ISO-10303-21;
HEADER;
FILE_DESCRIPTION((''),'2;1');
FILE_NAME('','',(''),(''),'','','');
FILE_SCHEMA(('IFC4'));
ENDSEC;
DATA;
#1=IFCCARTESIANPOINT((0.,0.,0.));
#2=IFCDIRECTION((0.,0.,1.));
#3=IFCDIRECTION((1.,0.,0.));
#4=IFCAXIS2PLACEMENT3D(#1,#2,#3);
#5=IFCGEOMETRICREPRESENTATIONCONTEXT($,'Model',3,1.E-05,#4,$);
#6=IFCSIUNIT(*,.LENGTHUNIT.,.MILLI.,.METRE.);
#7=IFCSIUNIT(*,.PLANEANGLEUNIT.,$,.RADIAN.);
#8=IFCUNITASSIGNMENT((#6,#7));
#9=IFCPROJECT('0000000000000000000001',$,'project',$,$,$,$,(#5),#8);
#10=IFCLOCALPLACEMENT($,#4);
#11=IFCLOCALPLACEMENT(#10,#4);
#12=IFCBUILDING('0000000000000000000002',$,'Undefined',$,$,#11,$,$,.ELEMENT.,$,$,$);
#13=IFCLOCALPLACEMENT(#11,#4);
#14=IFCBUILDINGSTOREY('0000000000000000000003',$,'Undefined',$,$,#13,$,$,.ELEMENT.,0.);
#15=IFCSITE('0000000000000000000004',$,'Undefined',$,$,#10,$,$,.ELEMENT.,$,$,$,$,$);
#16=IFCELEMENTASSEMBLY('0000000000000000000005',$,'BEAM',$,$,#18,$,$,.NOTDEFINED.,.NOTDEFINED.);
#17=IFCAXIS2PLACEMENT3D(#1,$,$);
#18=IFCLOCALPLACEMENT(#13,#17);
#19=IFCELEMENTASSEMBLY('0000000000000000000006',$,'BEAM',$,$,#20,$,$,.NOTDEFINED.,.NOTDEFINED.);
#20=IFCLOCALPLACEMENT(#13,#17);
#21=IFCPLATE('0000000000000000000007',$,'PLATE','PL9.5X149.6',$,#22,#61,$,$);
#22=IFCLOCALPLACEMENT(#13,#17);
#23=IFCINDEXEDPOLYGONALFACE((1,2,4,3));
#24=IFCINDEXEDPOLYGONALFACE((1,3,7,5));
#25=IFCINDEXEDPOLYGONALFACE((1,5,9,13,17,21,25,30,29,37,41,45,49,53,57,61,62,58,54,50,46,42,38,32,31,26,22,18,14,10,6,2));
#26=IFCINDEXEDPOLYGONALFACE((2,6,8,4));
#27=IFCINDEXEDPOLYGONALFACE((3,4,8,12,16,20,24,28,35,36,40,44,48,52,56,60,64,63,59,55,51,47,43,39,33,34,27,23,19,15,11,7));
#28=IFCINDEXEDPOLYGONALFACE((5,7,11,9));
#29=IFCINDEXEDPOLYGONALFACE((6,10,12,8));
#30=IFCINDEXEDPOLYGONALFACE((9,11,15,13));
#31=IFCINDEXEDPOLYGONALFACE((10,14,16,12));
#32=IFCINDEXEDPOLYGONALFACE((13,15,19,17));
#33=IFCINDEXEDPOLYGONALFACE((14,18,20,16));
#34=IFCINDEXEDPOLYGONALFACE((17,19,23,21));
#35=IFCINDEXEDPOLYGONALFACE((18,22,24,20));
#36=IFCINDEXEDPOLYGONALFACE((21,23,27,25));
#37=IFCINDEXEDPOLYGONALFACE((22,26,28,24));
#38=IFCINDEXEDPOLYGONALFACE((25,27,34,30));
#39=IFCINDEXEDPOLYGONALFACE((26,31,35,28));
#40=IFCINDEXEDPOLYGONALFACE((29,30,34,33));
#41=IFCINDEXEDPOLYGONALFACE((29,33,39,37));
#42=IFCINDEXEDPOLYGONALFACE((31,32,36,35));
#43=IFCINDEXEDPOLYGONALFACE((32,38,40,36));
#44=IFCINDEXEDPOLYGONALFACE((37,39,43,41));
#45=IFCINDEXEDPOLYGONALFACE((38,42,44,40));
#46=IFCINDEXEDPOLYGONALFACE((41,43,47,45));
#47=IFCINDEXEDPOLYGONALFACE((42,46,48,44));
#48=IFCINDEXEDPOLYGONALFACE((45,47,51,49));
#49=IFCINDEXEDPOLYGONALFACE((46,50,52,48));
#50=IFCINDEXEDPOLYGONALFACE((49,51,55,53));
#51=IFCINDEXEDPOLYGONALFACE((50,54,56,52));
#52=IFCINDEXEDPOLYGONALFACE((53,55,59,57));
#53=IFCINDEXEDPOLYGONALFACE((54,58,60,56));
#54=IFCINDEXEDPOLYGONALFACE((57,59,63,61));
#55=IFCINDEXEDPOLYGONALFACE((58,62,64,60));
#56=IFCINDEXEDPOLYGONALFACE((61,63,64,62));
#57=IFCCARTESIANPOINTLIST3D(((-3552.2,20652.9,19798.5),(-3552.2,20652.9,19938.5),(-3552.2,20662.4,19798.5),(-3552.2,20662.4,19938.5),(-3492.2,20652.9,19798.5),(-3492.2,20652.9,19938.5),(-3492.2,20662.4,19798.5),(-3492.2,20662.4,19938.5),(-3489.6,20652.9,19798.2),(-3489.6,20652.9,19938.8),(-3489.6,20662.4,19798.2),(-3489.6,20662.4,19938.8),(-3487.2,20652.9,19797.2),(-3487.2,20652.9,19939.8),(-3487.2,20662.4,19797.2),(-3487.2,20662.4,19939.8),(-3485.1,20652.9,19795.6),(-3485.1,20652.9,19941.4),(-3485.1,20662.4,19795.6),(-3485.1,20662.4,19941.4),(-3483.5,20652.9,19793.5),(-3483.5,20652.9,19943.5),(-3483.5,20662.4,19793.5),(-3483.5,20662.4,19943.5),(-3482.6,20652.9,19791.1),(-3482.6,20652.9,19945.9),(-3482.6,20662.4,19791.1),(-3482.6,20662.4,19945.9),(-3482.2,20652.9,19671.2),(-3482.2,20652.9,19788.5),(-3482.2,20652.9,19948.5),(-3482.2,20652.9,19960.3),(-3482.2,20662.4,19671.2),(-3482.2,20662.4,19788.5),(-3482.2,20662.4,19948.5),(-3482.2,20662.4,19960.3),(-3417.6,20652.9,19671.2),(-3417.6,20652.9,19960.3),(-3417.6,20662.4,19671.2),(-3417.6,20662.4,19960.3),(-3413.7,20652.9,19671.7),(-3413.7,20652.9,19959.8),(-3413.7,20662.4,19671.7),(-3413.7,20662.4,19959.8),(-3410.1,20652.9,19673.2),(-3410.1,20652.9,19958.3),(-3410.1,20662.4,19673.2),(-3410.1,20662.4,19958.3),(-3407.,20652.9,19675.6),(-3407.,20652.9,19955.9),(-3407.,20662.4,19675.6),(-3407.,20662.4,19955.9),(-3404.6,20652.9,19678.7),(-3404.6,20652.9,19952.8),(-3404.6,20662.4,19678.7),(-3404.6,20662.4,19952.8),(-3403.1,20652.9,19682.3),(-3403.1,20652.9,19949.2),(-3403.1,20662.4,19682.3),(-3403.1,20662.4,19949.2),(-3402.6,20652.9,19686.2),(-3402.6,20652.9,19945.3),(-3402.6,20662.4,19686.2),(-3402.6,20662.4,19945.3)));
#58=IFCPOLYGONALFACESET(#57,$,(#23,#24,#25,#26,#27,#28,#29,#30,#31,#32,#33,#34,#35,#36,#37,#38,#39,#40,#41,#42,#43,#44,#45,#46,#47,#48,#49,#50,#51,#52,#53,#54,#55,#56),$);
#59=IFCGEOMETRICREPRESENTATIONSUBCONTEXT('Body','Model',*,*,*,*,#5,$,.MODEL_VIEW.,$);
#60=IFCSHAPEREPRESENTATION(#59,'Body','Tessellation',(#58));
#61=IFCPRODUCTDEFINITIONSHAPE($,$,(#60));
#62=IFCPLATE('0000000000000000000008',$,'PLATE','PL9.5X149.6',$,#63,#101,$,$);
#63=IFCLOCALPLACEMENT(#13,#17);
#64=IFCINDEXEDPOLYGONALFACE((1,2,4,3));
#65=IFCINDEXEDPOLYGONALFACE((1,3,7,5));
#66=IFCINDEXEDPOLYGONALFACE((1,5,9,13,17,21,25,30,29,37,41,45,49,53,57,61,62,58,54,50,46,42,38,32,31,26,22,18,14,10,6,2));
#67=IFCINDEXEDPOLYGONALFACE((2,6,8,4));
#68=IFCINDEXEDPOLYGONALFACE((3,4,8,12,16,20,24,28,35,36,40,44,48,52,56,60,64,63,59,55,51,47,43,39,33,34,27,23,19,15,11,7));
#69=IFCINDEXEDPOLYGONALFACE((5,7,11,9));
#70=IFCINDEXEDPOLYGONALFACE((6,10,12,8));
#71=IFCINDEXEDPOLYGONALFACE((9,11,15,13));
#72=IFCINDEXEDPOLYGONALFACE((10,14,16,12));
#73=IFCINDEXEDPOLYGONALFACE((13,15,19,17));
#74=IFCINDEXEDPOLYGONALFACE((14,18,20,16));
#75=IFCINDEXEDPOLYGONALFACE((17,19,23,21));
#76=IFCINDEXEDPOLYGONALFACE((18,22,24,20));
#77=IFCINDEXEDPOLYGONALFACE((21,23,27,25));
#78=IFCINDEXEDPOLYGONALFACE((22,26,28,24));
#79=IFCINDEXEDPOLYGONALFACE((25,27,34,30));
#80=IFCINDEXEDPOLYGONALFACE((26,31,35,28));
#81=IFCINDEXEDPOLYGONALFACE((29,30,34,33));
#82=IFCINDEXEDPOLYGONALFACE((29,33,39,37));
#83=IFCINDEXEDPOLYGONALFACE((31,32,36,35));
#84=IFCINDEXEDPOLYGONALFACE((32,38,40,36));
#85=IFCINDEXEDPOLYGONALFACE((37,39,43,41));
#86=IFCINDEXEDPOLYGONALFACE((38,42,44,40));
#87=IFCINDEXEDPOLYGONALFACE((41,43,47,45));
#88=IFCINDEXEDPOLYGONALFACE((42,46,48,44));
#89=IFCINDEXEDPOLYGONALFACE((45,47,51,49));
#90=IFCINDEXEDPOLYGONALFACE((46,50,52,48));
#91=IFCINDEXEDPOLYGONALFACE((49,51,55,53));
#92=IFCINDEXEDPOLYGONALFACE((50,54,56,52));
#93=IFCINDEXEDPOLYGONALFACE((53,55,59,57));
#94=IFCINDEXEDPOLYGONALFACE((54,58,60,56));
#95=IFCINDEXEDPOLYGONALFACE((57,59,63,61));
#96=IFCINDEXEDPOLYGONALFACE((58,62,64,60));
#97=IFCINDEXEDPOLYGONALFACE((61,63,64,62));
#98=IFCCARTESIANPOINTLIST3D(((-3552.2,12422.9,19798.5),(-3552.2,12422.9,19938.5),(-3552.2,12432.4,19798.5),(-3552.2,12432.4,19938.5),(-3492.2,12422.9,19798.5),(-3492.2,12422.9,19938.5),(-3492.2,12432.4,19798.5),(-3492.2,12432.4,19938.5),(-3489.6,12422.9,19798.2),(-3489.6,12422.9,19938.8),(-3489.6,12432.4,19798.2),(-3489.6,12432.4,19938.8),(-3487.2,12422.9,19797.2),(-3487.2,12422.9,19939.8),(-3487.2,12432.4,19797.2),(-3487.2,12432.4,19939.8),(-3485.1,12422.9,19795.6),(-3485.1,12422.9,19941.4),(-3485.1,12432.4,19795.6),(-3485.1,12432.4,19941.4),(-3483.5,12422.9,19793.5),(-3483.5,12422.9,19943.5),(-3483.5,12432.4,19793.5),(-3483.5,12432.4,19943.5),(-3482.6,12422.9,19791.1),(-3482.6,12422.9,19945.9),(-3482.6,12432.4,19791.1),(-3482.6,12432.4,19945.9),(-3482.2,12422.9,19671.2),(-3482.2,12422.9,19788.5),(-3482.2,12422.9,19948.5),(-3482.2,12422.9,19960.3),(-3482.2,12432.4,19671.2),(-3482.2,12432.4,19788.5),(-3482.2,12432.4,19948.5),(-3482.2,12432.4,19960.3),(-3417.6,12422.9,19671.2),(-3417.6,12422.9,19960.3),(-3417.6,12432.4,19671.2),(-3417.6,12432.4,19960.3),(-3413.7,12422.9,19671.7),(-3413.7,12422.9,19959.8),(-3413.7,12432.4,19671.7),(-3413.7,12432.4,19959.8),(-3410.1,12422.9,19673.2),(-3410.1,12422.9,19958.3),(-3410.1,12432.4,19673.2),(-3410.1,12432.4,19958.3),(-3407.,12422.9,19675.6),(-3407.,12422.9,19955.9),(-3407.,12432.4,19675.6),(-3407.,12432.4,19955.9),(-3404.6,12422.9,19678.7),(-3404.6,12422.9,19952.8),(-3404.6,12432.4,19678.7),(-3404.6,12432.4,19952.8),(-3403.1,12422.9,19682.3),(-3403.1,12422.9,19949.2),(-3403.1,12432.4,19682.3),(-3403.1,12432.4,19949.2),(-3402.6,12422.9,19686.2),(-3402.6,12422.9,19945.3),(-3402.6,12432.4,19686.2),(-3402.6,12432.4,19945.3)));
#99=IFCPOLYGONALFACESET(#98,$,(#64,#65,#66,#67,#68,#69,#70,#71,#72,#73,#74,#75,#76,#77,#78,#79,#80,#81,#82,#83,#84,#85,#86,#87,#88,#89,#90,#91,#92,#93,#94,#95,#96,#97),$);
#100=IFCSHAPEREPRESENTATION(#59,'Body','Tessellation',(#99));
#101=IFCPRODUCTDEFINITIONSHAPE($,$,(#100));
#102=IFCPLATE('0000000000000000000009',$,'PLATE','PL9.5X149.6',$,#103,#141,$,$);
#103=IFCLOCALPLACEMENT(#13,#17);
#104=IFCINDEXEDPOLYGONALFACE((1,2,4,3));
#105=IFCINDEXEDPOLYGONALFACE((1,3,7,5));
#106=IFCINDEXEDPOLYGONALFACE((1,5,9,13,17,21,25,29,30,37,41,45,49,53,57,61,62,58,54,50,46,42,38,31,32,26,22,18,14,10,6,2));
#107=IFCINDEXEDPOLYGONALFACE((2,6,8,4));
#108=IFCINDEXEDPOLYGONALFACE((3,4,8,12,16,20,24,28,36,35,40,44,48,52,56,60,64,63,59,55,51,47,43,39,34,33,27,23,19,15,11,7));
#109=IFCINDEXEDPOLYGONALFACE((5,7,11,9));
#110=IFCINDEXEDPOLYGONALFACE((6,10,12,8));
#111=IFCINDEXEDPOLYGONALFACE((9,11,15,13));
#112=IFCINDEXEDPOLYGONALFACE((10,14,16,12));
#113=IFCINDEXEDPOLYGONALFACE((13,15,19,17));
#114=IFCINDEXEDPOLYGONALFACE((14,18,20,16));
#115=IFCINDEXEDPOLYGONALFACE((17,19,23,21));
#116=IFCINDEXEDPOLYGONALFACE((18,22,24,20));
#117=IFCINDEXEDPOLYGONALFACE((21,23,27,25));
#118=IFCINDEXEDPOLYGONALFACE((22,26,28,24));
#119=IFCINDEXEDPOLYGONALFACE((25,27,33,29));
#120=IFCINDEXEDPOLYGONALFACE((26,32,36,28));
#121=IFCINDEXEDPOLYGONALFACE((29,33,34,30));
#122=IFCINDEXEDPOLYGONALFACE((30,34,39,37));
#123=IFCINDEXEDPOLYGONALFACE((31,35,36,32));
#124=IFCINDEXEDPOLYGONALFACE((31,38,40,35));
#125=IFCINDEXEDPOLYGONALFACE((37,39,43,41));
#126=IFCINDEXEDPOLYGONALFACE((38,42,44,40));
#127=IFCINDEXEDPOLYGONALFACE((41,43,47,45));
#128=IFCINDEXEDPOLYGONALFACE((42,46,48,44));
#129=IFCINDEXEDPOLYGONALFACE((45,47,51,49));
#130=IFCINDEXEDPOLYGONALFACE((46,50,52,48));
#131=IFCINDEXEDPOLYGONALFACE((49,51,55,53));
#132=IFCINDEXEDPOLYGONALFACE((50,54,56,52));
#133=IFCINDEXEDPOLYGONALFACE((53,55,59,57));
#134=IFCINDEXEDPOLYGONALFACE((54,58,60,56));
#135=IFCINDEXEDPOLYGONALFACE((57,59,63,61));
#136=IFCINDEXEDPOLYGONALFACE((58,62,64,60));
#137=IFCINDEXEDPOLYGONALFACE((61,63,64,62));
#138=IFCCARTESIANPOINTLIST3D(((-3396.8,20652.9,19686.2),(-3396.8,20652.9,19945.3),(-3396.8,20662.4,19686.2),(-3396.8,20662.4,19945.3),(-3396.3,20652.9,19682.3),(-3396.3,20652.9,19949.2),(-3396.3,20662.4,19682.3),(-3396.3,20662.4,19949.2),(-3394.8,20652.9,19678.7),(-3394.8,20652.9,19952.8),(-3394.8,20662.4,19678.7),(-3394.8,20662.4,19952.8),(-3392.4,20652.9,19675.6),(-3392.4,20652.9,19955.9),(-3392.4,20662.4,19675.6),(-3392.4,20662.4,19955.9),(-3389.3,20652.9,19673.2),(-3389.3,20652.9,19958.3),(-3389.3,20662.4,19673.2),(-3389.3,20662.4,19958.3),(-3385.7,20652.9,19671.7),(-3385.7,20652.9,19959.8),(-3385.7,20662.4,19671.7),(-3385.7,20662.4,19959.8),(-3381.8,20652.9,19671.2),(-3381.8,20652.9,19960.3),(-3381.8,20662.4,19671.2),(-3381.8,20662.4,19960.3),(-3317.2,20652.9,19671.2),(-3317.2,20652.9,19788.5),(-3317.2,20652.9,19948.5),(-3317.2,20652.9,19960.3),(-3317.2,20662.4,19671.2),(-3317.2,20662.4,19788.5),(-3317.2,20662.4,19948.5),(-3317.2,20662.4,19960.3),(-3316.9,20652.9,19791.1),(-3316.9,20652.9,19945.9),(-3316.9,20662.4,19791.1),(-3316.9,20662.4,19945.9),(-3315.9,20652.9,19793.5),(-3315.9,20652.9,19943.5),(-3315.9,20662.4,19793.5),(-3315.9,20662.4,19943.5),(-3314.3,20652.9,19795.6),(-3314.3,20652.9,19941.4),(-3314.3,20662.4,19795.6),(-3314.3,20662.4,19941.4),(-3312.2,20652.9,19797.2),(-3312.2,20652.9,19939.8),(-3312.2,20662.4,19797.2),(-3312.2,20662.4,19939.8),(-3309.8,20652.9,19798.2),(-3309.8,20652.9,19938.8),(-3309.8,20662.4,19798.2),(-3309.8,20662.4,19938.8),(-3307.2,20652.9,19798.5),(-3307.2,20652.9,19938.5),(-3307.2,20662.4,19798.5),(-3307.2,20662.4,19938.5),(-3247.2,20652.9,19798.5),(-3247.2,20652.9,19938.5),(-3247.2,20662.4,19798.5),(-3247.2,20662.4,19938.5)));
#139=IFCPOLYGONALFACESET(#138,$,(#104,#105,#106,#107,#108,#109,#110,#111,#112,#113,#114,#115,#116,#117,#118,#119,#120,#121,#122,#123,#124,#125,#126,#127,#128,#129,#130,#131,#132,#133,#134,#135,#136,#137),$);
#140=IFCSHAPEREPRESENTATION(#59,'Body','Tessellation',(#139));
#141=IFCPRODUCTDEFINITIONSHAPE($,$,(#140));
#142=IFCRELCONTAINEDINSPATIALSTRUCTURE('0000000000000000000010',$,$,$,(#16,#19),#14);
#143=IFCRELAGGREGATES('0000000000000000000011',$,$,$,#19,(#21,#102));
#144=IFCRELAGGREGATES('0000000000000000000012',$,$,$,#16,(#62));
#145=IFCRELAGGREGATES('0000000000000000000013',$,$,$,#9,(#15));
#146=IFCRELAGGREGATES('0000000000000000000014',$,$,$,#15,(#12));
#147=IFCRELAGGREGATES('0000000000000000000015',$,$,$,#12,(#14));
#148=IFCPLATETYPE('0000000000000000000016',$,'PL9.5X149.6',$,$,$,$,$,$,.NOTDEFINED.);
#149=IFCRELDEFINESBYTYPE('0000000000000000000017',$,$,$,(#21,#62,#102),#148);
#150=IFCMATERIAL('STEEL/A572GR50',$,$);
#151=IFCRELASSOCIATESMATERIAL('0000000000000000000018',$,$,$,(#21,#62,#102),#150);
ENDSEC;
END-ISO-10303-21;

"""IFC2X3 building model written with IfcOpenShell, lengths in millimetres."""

from ifc_helpers import new_model, si_unit, frame, frame_2d, origin_with_axes, place, context, subcontext, project, spatial, polyline, circle_curve, parameter, trimmed, segment, composite_curve, outline, extrude, material, type_object, element, aggregate, save


model = new_model("IFC2X3")

# Units and contexts
model_context = context("Model", 3, precision=1e-05, world=origin_with_axes())
body_context = subcontext(model_context, "Body", "Model", "MODEL_VIEW")
ifc_project = project(units=[si_unit("LENGTHUNIT", "METRE", prefix="MILLI"), si_unit("PLANEANGLEUNIT", "RADIAN")], contexts=[model_context])

# Site, building, storey
site_placement = place(None, origin_with_axes())
site = spatial("IfcSite", under=ifc_project, at=site_placement, Name="Undefined", CompositionType="ELEMENT")
building_placement = place(site_placement, origin_with_axes())
building = spatial("IfcBuilding", under=site, at=building_placement, Name="Undefined", CompositionType="ELEMENT")
storey_placement = place(building_placement, origin_with_axes())
storey = spatial("IfcBuildingStorey", under=building, at=storey_placement, Name="Undefined", CompositionType="ELEMENT", Elevation=0.0)

# Shared definitions
ifc_material_1 = material(Name="STEEL/A572GR50")

# Element assembly
assembly_1_placement = place(storey_placement, origin_with_axes())
assembly_1 = element("IfcElementAssembly", 1, at=assembly_1_placement, inside=storey, Name="BEAM", AssemblyPlace="NOTDEFINED", PredefinedType="NOTDEFINED")

# Element assembly, plate
assembly_2_placement = place(storey_placement, origin_with_axes())
assembly_2 = element("IfcElementAssembly", 2, at=assembly_2_placement, inside=storey, Name="BEAM", AssemblyPlace="NOTDEFINED", PredefinedType="NOTDEFINED")
plate_type_1 = type_object("IfcPlateType", Name="PL9.5X149.6", PredefinedType="NOTDEFINED")
plate_1_placement = place(assembly_2_placement, frame((-3402.6, 20657.7, 19960.3), z_axis=(0.0, 1.0, 0.0), x_axis=(0.0, 0.0, -1.0)))
plate_1 = element("IfcPlate", 3, at=plate_1_placement, type_object=plate_type_1, material=ifc_material_1, Name="PLATE", Description="PL9.5X149.6", context=body_context, shape_type="SweptSolid", body=[
    extrude(outline(composite_curve([segment(trimmed(circle_curve(frame_2d((15.0, 15.0), x_axis=(-1.0, 0.0)), 15.0), [parameter(0.0)], [parameter(1.570796)], True, "PARAMETER"), True, "CONTINUOUS"), segment(polyline([(15.0, 0.0), (274.1, 0.0)]), True, "CONTINUOUS"), segment(trimmed(circle_curve(frame_2d((274.1, 15.0), x_axis=(0.0, -1.0)), 15.0), [parameter(0.0)], [parameter(1.570796)], True, "PARAMETER"), True, "CONTINUOUS"), segment(polyline([(289.1, 15.0), (289.1, 79.6), (171.8, 79.6)]), True, "CONTINUOUS"), segment(trimmed(circle_curve(frame_2d((171.8, 89.6), x_axis=(0.0, -1.0)), 10.0), [parameter(0.0)], [parameter(4.712389)], False, "PARAMETER"), True, "CONTINUOUS"), segment(polyline([(161.8, 89.6), (161.8, 149.6), (21.8, 149.6), (21.8, 89.6)]), True, "CONTINUOUS"), segment(trimmed(circle_curve(frame_2d((11.8, 89.6), x_axis=(1.0, 0.0)), 10.0), [parameter(0.0)], [parameter(4.712389)], False, "PARAMETER"), True, "CONTINUOUS"), segment(polyline([(11.8, 79.6), (0.0, 79.6), (0.0, 15.0)]), True, "CONTINUOUS")], self_intersect=True)), frame((0.0, 0.0, -4.8), z_axis=(0.0, 0.0, 1.0), x_axis=(1.0, 0.0, 0.0)), (0.0, 0.0, 1.0), 9.5),
])

# Plates
plate_2_placement = place(assembly_1_placement, frame((-3402.6, 12427.7, 19960.3), z_axis=(0.0, 1.0, 0.0), x_axis=(0.0, 0.0, -1.0)))
plate_2 = element("IfcPlate", 4, at=plate_2_placement, type_object=plate_type_1, material=ifc_material_1, Name="PLATE", Description="PL9.5X149.6", context=body_context, shape_type="SweptSolid", body=[
    extrude(outline(composite_curve([segment(trimmed(circle_curve(frame_2d((15.0, 15.0), x_axis=(-1.0, 0.0)), 15.0), [parameter(0.0)], [parameter(1.570796)], True, "PARAMETER"), True, "CONTINUOUS"), segment(polyline([(15.0, 0.0), (274.1, 0.0)]), True, "CONTINUOUS"), segment(trimmed(circle_curve(frame_2d((274.1, 15.0), x_axis=(0.0, -1.0)), 15.0), [parameter(0.0)], [parameter(1.570796)], True, "PARAMETER"), True, "CONTINUOUS"), segment(polyline([(289.1, 15.0), (289.1, 79.6), (171.8, 79.6)]), True, "CONTINUOUS"), segment(trimmed(circle_curve(frame_2d((171.8, 89.6), x_axis=(0.0, -1.0)), 10.0), [parameter(0.0)], [parameter(4.712389)], False, "PARAMETER"), True, "CONTINUOUS"), segment(polyline([(161.8, 89.6), (161.8, 149.6), (21.8, 149.6), (21.8, 89.6)]), True, "CONTINUOUS"), segment(trimmed(circle_curve(frame_2d((11.8, 89.6), x_axis=(1.0, 0.0)), 10.0), [parameter(0.0)], [parameter(4.712389)], False, "PARAMETER"), True, "CONTINUOUS"), segment(polyline([(11.8, 79.6), (0.0, 79.6), (0.0, 15.0)]), True, "CONTINUOUS")], self_intersect=True)), frame((0.0, 0.0, -4.8), z_axis=(0.0, 0.0, 1.0), x_axis=(1.0, 0.0, 0.0)), (0.0, 0.0, 1.0), 9.5),
])
plate_3_placement = place(assembly_2_placement, frame((-3396.8, 20657.7, 19960.3), z_axis=(0.0, -1.0, 0.0), x_axis=(0.0, 0.0, -1.0)))
plate_3 = element("IfcPlate", 5, at=plate_3_placement, type_object=plate_type_1, material=ifc_material_1, Name="PLATE", Description="PL9.5X149.6", context=body_context, shape_type="SweptSolid", body=[
    extrude(outline(composite_curve([segment(trimmed(circle_curve(frame_2d((15.0, 15.0), x_axis=(-1.0, 0.0)), 15.0), [parameter(0.0)], [parameter(1.570796)], True, "PARAMETER"), True, "CONTINUOUS"), segment(polyline([(15.0, 0.0), (274.1, 0.0)]), True, "CONTINUOUS"), segment(trimmed(circle_curve(frame_2d((274.1, 15.0), x_axis=(0.0, -1.0)), 15.0), [parameter(0.0)], [parameter(1.570796)], True, "PARAMETER"), True, "CONTINUOUS"), segment(polyline([(289.1, 15.0), (289.1, 79.6), (171.8, 79.6)]), True, "CONTINUOUS"), segment(trimmed(circle_curve(frame_2d((171.8, 89.6), x_axis=(0.0, -1.0)), 10.0), [parameter(0.0)], [parameter(4.712389)], False, "PARAMETER"), True, "CONTINUOUS"), segment(polyline([(161.8, 89.6), (161.8, 149.6), (21.8, 149.6), (21.8, 89.6)]), True, "CONTINUOUS"), segment(trimmed(circle_curve(frame_2d((11.8, 89.6), x_axis=(1.0, 0.0)), 10.0), [parameter(0.0)], [parameter(4.712389)], False, "PARAMETER"), True, "CONTINUOUS"), segment(polyline([(11.8, 79.6), (0.0, 79.6), (0.0, 15.0)]), True, "CONTINUOUS")], self_intersect=True)), frame((0.0, 0.0, -4.8), z_axis=(0.0, 0.0, 1.0), x_axis=(1.0, 0.0, 0.0)), (0.0, 0.0, 1.0), 9.5),
])

aggregate(assembly_2, [plate_1, plate_3])
aggregate(assembly_1, [plate_2])

save(model, "model.ifc")
